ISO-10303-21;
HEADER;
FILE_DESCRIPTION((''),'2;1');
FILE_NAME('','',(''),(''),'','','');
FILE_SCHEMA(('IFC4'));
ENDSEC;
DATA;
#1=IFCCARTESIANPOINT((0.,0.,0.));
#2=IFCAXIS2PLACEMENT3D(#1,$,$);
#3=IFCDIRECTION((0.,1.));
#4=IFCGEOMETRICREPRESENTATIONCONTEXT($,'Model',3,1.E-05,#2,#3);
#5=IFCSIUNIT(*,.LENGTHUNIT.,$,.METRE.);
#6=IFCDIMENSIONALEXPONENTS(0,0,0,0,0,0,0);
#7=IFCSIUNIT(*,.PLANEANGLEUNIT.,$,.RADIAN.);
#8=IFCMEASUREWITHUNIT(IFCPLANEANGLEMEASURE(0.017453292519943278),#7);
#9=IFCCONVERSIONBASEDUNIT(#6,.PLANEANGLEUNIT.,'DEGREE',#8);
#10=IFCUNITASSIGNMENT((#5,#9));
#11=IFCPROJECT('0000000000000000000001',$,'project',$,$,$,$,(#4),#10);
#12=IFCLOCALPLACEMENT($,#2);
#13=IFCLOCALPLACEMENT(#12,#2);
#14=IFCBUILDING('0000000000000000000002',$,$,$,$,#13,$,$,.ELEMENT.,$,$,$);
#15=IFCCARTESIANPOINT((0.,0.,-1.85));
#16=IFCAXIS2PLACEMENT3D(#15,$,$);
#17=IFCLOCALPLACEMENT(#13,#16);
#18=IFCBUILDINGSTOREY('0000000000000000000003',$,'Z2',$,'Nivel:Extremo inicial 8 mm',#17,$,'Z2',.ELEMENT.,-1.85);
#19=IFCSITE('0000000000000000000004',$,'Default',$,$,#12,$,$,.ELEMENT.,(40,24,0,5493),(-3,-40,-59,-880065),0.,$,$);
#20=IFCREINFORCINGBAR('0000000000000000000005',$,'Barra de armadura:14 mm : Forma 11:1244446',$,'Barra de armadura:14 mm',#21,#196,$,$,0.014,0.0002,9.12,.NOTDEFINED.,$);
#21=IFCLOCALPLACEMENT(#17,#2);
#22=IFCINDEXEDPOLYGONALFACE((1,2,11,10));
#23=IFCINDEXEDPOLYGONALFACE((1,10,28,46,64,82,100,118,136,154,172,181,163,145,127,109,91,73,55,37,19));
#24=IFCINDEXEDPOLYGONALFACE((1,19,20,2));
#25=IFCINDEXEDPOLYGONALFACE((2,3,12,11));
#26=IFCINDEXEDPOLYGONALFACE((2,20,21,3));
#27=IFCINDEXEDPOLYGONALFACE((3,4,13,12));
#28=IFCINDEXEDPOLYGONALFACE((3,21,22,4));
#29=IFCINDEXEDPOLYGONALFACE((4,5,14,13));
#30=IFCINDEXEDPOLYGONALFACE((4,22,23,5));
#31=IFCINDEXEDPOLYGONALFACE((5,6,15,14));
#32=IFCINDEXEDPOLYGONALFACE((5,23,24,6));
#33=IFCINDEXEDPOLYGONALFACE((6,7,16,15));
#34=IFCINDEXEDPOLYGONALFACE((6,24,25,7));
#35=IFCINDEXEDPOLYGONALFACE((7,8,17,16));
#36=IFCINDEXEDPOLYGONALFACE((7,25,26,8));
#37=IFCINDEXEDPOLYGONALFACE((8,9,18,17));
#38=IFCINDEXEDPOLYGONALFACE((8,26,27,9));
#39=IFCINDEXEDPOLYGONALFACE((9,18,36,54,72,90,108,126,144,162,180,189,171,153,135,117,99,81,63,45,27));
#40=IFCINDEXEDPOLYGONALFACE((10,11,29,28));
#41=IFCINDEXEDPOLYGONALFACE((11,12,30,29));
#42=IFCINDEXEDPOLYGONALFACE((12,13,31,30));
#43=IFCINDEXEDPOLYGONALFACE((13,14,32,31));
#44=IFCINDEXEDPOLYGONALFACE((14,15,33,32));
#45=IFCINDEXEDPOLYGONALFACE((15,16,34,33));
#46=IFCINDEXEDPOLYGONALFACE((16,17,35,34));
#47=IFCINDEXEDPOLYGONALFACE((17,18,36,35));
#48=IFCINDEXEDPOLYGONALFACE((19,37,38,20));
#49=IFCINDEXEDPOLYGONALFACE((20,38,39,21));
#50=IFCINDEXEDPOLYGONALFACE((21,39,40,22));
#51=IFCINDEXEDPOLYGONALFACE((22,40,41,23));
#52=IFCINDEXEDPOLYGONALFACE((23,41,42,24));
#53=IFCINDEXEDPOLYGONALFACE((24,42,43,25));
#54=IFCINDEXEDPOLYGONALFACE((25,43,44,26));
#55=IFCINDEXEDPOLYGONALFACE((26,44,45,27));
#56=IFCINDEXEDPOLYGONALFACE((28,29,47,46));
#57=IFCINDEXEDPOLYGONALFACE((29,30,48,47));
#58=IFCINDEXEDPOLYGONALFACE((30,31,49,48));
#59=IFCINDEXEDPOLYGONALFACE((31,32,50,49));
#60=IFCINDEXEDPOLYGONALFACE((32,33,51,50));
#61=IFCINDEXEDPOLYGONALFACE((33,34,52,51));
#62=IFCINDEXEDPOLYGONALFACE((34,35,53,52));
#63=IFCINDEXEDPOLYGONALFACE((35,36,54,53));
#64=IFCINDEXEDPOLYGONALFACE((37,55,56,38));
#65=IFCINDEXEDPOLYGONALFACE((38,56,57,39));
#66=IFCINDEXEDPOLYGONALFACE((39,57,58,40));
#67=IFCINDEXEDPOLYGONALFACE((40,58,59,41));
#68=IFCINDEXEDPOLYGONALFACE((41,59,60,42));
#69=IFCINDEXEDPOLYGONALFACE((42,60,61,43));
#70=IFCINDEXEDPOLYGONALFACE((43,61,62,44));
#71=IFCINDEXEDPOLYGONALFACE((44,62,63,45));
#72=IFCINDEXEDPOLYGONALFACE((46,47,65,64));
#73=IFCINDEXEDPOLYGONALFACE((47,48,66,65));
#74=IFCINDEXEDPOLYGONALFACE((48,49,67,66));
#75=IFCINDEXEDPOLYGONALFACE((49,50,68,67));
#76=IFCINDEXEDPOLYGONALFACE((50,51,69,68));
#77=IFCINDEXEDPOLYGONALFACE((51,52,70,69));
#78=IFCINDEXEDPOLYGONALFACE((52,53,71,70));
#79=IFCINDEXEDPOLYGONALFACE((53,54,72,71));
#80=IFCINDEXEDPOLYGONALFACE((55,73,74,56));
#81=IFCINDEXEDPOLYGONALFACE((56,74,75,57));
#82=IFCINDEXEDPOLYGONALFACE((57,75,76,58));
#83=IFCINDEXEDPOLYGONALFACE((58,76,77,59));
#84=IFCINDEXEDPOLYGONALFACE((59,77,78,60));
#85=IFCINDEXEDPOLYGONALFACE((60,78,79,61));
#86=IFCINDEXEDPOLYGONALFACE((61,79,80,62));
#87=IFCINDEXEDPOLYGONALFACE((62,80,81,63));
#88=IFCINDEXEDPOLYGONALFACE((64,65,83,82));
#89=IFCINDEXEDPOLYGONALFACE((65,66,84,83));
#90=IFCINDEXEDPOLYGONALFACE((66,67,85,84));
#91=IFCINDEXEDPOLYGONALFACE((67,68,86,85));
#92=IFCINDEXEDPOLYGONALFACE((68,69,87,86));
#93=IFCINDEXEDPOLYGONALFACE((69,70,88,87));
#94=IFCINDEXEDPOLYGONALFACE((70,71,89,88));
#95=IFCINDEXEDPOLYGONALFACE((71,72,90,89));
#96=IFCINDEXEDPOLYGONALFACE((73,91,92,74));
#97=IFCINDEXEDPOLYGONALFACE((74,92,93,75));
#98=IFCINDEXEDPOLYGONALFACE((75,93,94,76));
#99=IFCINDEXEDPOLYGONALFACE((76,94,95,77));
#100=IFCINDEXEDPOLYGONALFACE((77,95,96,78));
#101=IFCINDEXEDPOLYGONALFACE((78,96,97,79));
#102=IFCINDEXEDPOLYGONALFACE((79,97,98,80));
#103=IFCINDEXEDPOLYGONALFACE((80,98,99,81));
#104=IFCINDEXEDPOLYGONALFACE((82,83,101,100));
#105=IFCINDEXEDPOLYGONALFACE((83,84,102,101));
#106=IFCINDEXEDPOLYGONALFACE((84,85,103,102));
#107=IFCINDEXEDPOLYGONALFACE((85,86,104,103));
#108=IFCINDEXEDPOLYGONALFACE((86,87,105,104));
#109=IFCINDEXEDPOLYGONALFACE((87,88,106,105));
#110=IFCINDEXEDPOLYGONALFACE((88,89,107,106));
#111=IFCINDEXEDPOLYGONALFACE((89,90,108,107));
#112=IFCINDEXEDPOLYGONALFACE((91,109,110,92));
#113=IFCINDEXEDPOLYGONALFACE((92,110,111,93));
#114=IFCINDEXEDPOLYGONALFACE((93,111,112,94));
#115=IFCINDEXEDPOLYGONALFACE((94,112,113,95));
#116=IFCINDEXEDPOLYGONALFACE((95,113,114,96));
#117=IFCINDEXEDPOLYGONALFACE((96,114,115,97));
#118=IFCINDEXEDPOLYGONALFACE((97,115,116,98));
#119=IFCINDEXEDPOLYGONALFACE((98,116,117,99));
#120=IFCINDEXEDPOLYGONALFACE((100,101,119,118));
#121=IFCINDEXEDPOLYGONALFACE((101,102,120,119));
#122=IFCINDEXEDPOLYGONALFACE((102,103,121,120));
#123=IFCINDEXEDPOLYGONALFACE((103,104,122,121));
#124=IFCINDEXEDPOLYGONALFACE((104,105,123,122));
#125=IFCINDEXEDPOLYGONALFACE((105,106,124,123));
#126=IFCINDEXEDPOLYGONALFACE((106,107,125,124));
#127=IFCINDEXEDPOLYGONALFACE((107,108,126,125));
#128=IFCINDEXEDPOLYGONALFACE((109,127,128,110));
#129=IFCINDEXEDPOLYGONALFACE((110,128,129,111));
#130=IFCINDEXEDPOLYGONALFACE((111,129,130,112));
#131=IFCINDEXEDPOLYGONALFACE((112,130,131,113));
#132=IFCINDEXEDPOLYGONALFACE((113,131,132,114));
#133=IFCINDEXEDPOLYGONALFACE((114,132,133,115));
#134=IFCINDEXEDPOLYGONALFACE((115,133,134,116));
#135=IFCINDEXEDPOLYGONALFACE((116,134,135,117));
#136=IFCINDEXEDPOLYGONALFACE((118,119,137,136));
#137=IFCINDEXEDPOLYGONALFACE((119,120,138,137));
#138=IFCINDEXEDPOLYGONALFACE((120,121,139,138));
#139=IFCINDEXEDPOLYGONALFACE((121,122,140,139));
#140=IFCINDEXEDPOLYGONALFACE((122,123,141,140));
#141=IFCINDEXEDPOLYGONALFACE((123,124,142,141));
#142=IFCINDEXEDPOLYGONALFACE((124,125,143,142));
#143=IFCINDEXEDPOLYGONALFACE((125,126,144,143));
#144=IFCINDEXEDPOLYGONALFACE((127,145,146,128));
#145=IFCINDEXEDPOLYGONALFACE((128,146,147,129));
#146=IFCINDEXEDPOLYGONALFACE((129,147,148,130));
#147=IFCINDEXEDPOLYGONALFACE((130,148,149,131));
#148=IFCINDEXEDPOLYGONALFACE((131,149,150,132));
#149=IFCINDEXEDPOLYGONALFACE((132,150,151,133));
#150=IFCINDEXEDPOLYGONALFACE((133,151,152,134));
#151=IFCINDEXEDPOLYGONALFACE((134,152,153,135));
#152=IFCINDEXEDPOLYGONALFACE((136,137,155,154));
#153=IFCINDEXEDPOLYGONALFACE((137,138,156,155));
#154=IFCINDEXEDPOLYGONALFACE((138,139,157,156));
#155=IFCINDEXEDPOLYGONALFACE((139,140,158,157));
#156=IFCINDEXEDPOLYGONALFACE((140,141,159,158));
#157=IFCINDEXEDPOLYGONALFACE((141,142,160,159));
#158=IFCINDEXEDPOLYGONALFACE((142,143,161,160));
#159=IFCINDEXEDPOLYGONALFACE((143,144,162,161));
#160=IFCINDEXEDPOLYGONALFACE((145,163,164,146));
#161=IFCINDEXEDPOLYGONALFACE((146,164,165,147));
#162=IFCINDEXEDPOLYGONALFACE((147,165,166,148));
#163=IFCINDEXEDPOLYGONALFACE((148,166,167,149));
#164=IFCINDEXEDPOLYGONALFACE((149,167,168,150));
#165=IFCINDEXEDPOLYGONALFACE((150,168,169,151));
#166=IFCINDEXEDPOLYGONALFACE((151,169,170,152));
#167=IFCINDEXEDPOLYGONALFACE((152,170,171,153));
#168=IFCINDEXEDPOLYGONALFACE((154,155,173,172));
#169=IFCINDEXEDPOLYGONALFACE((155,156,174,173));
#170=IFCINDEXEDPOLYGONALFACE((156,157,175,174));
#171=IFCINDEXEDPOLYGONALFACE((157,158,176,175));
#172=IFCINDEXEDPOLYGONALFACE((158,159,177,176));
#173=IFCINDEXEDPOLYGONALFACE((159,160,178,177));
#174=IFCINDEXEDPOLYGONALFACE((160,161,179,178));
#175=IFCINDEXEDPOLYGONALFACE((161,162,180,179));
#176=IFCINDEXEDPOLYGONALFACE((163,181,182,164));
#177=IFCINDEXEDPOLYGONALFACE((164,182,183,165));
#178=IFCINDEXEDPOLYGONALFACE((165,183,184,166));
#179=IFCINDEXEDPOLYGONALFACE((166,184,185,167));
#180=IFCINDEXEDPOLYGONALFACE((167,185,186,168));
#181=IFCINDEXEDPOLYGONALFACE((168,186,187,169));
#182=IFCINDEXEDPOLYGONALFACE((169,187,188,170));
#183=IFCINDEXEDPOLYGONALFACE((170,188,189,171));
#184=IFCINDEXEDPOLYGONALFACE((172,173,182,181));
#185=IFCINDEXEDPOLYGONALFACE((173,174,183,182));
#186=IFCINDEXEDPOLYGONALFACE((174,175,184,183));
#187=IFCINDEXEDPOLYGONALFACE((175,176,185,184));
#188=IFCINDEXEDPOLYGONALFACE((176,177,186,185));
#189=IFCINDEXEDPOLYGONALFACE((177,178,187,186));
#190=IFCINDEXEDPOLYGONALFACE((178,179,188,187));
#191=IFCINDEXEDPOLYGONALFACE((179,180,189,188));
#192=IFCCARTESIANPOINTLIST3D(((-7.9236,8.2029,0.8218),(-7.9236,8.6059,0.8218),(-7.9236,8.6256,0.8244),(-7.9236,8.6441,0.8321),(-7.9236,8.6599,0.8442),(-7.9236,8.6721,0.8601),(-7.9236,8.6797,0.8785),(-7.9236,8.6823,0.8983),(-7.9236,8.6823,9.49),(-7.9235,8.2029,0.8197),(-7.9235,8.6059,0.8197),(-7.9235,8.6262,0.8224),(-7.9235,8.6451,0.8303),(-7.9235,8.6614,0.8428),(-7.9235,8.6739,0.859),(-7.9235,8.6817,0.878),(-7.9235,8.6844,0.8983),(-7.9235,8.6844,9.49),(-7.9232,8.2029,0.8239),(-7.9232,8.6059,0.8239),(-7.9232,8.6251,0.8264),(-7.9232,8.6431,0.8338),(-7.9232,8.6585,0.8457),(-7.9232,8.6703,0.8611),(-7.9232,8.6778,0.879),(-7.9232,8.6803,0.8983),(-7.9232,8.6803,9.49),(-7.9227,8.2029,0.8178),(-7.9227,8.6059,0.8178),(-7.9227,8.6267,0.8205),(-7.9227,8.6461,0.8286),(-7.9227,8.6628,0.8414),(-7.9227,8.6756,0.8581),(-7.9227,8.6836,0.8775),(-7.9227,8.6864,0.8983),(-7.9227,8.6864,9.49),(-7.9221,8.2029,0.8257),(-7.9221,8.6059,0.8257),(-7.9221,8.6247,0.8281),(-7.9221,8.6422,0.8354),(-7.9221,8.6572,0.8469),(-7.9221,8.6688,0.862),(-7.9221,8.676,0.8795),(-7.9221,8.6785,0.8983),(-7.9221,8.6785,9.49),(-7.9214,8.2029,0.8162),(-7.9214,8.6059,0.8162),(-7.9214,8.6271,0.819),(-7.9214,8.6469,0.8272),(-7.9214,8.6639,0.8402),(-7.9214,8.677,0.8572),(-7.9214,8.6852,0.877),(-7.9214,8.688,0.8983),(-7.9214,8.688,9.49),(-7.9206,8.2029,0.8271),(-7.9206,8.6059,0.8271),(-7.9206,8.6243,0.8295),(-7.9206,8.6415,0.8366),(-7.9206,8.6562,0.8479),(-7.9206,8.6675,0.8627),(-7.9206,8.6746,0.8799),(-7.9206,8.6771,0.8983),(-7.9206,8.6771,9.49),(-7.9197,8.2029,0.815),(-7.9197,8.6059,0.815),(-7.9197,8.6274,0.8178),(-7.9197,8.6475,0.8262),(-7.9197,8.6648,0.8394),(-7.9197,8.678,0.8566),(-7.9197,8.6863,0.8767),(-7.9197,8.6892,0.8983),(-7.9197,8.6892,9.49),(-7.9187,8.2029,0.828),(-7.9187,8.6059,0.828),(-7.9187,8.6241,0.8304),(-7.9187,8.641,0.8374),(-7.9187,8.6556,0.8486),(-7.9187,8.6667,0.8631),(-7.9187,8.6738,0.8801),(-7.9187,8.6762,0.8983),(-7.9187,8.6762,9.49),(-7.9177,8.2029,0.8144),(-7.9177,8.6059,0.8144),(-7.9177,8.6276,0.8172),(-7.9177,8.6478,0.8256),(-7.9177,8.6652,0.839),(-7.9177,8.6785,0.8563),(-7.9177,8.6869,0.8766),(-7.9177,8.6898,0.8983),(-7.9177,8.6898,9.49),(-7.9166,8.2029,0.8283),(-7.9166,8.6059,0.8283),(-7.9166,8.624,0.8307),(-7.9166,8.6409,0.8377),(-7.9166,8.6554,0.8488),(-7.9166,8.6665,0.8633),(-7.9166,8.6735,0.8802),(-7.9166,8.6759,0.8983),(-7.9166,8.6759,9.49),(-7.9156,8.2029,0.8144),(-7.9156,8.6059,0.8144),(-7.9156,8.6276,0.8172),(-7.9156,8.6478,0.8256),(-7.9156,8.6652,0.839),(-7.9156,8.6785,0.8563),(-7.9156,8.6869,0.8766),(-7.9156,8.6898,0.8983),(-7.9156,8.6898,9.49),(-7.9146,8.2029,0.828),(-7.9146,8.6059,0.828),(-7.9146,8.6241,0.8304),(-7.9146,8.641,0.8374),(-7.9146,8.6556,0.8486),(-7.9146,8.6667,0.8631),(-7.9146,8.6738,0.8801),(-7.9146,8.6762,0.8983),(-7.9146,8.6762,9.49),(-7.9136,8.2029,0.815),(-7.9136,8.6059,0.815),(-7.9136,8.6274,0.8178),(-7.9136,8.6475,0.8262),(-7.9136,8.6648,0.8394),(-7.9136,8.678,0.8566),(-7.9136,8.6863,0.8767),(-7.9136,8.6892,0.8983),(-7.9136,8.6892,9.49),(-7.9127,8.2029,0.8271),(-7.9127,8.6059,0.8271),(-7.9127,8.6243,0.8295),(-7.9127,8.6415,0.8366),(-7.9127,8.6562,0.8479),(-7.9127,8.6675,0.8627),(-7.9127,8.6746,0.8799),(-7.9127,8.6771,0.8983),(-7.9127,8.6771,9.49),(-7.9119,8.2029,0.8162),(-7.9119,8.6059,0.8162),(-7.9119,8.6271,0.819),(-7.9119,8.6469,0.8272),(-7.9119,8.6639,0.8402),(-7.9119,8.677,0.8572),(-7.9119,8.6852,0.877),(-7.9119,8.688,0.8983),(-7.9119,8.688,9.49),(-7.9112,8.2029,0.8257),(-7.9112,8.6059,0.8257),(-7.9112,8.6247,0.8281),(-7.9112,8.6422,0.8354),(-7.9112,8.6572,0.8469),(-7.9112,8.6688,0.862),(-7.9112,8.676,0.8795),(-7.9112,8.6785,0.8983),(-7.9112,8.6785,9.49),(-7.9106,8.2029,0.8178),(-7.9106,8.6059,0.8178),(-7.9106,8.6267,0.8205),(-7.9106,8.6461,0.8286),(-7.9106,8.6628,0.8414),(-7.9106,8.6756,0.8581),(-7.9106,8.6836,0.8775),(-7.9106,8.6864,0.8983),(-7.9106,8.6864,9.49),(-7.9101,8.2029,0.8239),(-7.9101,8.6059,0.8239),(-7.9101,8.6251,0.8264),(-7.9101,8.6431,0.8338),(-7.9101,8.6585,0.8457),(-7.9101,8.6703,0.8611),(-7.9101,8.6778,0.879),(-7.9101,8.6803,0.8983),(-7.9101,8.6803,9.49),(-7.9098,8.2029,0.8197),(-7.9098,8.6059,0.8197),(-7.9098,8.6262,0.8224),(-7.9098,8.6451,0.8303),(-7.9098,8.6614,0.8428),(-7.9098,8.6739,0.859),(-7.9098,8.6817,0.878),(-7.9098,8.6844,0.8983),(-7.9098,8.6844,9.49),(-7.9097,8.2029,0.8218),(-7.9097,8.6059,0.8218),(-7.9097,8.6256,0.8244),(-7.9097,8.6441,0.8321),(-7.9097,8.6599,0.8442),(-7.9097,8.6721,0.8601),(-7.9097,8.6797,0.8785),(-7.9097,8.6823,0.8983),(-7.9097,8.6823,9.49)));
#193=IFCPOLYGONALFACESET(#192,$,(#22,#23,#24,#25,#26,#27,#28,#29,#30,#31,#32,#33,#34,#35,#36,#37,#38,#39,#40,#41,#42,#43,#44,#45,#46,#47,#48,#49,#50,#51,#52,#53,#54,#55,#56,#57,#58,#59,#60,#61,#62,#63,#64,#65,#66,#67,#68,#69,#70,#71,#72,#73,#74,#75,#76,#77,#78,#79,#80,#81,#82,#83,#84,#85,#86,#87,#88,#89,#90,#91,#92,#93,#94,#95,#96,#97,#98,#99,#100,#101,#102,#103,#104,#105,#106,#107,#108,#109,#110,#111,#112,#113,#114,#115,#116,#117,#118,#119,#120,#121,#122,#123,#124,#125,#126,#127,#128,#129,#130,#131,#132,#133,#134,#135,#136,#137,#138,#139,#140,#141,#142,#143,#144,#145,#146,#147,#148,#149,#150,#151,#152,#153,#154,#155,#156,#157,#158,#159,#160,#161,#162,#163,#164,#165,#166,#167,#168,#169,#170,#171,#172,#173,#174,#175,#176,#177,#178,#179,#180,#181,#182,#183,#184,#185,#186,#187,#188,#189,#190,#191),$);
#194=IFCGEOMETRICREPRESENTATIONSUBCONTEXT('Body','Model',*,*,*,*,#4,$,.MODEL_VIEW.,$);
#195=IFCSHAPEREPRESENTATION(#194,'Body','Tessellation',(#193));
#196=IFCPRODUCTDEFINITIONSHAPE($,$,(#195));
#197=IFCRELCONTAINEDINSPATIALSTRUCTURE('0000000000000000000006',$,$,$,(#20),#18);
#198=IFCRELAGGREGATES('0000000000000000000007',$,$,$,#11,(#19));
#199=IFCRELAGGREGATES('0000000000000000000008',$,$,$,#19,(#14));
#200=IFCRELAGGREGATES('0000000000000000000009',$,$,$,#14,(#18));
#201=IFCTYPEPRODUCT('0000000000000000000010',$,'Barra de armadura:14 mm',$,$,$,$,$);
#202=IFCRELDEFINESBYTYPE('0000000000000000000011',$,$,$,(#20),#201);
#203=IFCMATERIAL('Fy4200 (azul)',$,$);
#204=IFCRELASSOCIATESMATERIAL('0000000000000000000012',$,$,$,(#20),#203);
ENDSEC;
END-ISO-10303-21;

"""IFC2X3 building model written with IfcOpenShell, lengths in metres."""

from ifc_helpers import new_model, entity, si_unit, converted_unit, direction, frame, origin, place, context, subcontext, project, spatial, material, type_object, element, save


model = new_model("IFC2X3")

# Units and contexts
model_context = context("Model", 3, precision=1e-05, world=origin(), true_north=direction((0.0, 1.0)))
body_context = subcontext(model_context, "Body", "Model", "MODEL_VIEW")
ifc_project = project(units=[si_unit("LENGTHUNIT", "METRE"), converted_unit("PLANEANGLEUNIT", "DEGREE", entity("IfcPlaneAngleMeasure", 0.017453292519943278), si_unit("PLANEANGLEUNIT", "RADIAN"), dimensions=[0, 0, 0, 0, 0, 0, 0])], contexts=[model_context])

# Site, building, storey
site_placement = place(None, origin())
site = spatial("IfcSite", under=ifc_project, at=site_placement, Name="Default", CompositionType="ELEMENT", RefLatitude=(40, 24, 0, 5493), RefLongitude=(-3, -40, -59, -880065), RefElevation=0.0)
building_placement = place(site_placement, origin())
building = spatial("IfcBuilding", under=site, at=building_placement, CompositionType="ELEMENT")
storey_placement = place(building_placement, frame((0.0, 0.0, -1.85)))
storey = spatial("IfcBuildingStorey", under=building, at=storey_placement, Name="Z2", ObjectType="Nivel:Extremo inicial 8 mm", LongName="Z2", CompositionType="ELEMENT", Elevation=-1.85)

# Reinforcing bar
ifc_material_1 = material(Name="Fy4200 (azul)")
type_product_1 = type_object("IfcTypeProduct", Name="Barra de armadura:14 mm")
reinforcing_bar_1_placement = place(storey_placement, origin())
element("IfcReinforcingBar", 1, at=reinforcing_bar_1_placement, inside=storey, type_object=type_product_1, material=ifc_material_1, Name="Barra de armadura:14 mm : Forma 11:1244446", ObjectType="Barra de armadura:14 mm", BarLength=9.12, BarRole="NOTDEFINED", CrossSectionArea=0.0002, NominalDiameter=0.014, context=body_context, shape_type="AdvancedSweptSolid", body=[
    entity("IfcSweptDiskSolid", entity("IfcCompositeCurve", [entity("IfcCompositeCurveSegment", "CONTINUOUS", True, entity("IfcPolyline", [entity("IfcCartesianPoint", [-7.9166, 8.6829, 9.49]), entity("IfcCartesianPoint", [-7.9166, 8.6829, 0.8983])])), entity("IfcCompositeCurveSegment", "CONTINUOUS", True, entity("IfcTrimmedCurve", entity("IfcCircle", entity("IfcAxis2Placement3D", entity("IfcCartesianPoint", [-7.9166, 8.6059, 0.8983]), entity("IfcDirection", [-1.0, 0.0, 0.0]), entity("IfcDirection", [0.0, 0.0, -1.0])), 0.077), [entity("IfcParameterValue", 270.0)], [entity("IfcParameterValue", 360.0)], True, "PARAMETER")), entity("IfcCompositeCurveSegment", "CONTINUOUS", True, entity("IfcPolyline", [entity("IfcCartesianPoint", [-7.9166, 8.6059, 0.8213]), entity("IfcCartesianPoint", [-7.9166, 8.2029, 0.8213])]))], False), 0.007, None, 0.0, 92.0),
])

save(model, "model.ifc")
